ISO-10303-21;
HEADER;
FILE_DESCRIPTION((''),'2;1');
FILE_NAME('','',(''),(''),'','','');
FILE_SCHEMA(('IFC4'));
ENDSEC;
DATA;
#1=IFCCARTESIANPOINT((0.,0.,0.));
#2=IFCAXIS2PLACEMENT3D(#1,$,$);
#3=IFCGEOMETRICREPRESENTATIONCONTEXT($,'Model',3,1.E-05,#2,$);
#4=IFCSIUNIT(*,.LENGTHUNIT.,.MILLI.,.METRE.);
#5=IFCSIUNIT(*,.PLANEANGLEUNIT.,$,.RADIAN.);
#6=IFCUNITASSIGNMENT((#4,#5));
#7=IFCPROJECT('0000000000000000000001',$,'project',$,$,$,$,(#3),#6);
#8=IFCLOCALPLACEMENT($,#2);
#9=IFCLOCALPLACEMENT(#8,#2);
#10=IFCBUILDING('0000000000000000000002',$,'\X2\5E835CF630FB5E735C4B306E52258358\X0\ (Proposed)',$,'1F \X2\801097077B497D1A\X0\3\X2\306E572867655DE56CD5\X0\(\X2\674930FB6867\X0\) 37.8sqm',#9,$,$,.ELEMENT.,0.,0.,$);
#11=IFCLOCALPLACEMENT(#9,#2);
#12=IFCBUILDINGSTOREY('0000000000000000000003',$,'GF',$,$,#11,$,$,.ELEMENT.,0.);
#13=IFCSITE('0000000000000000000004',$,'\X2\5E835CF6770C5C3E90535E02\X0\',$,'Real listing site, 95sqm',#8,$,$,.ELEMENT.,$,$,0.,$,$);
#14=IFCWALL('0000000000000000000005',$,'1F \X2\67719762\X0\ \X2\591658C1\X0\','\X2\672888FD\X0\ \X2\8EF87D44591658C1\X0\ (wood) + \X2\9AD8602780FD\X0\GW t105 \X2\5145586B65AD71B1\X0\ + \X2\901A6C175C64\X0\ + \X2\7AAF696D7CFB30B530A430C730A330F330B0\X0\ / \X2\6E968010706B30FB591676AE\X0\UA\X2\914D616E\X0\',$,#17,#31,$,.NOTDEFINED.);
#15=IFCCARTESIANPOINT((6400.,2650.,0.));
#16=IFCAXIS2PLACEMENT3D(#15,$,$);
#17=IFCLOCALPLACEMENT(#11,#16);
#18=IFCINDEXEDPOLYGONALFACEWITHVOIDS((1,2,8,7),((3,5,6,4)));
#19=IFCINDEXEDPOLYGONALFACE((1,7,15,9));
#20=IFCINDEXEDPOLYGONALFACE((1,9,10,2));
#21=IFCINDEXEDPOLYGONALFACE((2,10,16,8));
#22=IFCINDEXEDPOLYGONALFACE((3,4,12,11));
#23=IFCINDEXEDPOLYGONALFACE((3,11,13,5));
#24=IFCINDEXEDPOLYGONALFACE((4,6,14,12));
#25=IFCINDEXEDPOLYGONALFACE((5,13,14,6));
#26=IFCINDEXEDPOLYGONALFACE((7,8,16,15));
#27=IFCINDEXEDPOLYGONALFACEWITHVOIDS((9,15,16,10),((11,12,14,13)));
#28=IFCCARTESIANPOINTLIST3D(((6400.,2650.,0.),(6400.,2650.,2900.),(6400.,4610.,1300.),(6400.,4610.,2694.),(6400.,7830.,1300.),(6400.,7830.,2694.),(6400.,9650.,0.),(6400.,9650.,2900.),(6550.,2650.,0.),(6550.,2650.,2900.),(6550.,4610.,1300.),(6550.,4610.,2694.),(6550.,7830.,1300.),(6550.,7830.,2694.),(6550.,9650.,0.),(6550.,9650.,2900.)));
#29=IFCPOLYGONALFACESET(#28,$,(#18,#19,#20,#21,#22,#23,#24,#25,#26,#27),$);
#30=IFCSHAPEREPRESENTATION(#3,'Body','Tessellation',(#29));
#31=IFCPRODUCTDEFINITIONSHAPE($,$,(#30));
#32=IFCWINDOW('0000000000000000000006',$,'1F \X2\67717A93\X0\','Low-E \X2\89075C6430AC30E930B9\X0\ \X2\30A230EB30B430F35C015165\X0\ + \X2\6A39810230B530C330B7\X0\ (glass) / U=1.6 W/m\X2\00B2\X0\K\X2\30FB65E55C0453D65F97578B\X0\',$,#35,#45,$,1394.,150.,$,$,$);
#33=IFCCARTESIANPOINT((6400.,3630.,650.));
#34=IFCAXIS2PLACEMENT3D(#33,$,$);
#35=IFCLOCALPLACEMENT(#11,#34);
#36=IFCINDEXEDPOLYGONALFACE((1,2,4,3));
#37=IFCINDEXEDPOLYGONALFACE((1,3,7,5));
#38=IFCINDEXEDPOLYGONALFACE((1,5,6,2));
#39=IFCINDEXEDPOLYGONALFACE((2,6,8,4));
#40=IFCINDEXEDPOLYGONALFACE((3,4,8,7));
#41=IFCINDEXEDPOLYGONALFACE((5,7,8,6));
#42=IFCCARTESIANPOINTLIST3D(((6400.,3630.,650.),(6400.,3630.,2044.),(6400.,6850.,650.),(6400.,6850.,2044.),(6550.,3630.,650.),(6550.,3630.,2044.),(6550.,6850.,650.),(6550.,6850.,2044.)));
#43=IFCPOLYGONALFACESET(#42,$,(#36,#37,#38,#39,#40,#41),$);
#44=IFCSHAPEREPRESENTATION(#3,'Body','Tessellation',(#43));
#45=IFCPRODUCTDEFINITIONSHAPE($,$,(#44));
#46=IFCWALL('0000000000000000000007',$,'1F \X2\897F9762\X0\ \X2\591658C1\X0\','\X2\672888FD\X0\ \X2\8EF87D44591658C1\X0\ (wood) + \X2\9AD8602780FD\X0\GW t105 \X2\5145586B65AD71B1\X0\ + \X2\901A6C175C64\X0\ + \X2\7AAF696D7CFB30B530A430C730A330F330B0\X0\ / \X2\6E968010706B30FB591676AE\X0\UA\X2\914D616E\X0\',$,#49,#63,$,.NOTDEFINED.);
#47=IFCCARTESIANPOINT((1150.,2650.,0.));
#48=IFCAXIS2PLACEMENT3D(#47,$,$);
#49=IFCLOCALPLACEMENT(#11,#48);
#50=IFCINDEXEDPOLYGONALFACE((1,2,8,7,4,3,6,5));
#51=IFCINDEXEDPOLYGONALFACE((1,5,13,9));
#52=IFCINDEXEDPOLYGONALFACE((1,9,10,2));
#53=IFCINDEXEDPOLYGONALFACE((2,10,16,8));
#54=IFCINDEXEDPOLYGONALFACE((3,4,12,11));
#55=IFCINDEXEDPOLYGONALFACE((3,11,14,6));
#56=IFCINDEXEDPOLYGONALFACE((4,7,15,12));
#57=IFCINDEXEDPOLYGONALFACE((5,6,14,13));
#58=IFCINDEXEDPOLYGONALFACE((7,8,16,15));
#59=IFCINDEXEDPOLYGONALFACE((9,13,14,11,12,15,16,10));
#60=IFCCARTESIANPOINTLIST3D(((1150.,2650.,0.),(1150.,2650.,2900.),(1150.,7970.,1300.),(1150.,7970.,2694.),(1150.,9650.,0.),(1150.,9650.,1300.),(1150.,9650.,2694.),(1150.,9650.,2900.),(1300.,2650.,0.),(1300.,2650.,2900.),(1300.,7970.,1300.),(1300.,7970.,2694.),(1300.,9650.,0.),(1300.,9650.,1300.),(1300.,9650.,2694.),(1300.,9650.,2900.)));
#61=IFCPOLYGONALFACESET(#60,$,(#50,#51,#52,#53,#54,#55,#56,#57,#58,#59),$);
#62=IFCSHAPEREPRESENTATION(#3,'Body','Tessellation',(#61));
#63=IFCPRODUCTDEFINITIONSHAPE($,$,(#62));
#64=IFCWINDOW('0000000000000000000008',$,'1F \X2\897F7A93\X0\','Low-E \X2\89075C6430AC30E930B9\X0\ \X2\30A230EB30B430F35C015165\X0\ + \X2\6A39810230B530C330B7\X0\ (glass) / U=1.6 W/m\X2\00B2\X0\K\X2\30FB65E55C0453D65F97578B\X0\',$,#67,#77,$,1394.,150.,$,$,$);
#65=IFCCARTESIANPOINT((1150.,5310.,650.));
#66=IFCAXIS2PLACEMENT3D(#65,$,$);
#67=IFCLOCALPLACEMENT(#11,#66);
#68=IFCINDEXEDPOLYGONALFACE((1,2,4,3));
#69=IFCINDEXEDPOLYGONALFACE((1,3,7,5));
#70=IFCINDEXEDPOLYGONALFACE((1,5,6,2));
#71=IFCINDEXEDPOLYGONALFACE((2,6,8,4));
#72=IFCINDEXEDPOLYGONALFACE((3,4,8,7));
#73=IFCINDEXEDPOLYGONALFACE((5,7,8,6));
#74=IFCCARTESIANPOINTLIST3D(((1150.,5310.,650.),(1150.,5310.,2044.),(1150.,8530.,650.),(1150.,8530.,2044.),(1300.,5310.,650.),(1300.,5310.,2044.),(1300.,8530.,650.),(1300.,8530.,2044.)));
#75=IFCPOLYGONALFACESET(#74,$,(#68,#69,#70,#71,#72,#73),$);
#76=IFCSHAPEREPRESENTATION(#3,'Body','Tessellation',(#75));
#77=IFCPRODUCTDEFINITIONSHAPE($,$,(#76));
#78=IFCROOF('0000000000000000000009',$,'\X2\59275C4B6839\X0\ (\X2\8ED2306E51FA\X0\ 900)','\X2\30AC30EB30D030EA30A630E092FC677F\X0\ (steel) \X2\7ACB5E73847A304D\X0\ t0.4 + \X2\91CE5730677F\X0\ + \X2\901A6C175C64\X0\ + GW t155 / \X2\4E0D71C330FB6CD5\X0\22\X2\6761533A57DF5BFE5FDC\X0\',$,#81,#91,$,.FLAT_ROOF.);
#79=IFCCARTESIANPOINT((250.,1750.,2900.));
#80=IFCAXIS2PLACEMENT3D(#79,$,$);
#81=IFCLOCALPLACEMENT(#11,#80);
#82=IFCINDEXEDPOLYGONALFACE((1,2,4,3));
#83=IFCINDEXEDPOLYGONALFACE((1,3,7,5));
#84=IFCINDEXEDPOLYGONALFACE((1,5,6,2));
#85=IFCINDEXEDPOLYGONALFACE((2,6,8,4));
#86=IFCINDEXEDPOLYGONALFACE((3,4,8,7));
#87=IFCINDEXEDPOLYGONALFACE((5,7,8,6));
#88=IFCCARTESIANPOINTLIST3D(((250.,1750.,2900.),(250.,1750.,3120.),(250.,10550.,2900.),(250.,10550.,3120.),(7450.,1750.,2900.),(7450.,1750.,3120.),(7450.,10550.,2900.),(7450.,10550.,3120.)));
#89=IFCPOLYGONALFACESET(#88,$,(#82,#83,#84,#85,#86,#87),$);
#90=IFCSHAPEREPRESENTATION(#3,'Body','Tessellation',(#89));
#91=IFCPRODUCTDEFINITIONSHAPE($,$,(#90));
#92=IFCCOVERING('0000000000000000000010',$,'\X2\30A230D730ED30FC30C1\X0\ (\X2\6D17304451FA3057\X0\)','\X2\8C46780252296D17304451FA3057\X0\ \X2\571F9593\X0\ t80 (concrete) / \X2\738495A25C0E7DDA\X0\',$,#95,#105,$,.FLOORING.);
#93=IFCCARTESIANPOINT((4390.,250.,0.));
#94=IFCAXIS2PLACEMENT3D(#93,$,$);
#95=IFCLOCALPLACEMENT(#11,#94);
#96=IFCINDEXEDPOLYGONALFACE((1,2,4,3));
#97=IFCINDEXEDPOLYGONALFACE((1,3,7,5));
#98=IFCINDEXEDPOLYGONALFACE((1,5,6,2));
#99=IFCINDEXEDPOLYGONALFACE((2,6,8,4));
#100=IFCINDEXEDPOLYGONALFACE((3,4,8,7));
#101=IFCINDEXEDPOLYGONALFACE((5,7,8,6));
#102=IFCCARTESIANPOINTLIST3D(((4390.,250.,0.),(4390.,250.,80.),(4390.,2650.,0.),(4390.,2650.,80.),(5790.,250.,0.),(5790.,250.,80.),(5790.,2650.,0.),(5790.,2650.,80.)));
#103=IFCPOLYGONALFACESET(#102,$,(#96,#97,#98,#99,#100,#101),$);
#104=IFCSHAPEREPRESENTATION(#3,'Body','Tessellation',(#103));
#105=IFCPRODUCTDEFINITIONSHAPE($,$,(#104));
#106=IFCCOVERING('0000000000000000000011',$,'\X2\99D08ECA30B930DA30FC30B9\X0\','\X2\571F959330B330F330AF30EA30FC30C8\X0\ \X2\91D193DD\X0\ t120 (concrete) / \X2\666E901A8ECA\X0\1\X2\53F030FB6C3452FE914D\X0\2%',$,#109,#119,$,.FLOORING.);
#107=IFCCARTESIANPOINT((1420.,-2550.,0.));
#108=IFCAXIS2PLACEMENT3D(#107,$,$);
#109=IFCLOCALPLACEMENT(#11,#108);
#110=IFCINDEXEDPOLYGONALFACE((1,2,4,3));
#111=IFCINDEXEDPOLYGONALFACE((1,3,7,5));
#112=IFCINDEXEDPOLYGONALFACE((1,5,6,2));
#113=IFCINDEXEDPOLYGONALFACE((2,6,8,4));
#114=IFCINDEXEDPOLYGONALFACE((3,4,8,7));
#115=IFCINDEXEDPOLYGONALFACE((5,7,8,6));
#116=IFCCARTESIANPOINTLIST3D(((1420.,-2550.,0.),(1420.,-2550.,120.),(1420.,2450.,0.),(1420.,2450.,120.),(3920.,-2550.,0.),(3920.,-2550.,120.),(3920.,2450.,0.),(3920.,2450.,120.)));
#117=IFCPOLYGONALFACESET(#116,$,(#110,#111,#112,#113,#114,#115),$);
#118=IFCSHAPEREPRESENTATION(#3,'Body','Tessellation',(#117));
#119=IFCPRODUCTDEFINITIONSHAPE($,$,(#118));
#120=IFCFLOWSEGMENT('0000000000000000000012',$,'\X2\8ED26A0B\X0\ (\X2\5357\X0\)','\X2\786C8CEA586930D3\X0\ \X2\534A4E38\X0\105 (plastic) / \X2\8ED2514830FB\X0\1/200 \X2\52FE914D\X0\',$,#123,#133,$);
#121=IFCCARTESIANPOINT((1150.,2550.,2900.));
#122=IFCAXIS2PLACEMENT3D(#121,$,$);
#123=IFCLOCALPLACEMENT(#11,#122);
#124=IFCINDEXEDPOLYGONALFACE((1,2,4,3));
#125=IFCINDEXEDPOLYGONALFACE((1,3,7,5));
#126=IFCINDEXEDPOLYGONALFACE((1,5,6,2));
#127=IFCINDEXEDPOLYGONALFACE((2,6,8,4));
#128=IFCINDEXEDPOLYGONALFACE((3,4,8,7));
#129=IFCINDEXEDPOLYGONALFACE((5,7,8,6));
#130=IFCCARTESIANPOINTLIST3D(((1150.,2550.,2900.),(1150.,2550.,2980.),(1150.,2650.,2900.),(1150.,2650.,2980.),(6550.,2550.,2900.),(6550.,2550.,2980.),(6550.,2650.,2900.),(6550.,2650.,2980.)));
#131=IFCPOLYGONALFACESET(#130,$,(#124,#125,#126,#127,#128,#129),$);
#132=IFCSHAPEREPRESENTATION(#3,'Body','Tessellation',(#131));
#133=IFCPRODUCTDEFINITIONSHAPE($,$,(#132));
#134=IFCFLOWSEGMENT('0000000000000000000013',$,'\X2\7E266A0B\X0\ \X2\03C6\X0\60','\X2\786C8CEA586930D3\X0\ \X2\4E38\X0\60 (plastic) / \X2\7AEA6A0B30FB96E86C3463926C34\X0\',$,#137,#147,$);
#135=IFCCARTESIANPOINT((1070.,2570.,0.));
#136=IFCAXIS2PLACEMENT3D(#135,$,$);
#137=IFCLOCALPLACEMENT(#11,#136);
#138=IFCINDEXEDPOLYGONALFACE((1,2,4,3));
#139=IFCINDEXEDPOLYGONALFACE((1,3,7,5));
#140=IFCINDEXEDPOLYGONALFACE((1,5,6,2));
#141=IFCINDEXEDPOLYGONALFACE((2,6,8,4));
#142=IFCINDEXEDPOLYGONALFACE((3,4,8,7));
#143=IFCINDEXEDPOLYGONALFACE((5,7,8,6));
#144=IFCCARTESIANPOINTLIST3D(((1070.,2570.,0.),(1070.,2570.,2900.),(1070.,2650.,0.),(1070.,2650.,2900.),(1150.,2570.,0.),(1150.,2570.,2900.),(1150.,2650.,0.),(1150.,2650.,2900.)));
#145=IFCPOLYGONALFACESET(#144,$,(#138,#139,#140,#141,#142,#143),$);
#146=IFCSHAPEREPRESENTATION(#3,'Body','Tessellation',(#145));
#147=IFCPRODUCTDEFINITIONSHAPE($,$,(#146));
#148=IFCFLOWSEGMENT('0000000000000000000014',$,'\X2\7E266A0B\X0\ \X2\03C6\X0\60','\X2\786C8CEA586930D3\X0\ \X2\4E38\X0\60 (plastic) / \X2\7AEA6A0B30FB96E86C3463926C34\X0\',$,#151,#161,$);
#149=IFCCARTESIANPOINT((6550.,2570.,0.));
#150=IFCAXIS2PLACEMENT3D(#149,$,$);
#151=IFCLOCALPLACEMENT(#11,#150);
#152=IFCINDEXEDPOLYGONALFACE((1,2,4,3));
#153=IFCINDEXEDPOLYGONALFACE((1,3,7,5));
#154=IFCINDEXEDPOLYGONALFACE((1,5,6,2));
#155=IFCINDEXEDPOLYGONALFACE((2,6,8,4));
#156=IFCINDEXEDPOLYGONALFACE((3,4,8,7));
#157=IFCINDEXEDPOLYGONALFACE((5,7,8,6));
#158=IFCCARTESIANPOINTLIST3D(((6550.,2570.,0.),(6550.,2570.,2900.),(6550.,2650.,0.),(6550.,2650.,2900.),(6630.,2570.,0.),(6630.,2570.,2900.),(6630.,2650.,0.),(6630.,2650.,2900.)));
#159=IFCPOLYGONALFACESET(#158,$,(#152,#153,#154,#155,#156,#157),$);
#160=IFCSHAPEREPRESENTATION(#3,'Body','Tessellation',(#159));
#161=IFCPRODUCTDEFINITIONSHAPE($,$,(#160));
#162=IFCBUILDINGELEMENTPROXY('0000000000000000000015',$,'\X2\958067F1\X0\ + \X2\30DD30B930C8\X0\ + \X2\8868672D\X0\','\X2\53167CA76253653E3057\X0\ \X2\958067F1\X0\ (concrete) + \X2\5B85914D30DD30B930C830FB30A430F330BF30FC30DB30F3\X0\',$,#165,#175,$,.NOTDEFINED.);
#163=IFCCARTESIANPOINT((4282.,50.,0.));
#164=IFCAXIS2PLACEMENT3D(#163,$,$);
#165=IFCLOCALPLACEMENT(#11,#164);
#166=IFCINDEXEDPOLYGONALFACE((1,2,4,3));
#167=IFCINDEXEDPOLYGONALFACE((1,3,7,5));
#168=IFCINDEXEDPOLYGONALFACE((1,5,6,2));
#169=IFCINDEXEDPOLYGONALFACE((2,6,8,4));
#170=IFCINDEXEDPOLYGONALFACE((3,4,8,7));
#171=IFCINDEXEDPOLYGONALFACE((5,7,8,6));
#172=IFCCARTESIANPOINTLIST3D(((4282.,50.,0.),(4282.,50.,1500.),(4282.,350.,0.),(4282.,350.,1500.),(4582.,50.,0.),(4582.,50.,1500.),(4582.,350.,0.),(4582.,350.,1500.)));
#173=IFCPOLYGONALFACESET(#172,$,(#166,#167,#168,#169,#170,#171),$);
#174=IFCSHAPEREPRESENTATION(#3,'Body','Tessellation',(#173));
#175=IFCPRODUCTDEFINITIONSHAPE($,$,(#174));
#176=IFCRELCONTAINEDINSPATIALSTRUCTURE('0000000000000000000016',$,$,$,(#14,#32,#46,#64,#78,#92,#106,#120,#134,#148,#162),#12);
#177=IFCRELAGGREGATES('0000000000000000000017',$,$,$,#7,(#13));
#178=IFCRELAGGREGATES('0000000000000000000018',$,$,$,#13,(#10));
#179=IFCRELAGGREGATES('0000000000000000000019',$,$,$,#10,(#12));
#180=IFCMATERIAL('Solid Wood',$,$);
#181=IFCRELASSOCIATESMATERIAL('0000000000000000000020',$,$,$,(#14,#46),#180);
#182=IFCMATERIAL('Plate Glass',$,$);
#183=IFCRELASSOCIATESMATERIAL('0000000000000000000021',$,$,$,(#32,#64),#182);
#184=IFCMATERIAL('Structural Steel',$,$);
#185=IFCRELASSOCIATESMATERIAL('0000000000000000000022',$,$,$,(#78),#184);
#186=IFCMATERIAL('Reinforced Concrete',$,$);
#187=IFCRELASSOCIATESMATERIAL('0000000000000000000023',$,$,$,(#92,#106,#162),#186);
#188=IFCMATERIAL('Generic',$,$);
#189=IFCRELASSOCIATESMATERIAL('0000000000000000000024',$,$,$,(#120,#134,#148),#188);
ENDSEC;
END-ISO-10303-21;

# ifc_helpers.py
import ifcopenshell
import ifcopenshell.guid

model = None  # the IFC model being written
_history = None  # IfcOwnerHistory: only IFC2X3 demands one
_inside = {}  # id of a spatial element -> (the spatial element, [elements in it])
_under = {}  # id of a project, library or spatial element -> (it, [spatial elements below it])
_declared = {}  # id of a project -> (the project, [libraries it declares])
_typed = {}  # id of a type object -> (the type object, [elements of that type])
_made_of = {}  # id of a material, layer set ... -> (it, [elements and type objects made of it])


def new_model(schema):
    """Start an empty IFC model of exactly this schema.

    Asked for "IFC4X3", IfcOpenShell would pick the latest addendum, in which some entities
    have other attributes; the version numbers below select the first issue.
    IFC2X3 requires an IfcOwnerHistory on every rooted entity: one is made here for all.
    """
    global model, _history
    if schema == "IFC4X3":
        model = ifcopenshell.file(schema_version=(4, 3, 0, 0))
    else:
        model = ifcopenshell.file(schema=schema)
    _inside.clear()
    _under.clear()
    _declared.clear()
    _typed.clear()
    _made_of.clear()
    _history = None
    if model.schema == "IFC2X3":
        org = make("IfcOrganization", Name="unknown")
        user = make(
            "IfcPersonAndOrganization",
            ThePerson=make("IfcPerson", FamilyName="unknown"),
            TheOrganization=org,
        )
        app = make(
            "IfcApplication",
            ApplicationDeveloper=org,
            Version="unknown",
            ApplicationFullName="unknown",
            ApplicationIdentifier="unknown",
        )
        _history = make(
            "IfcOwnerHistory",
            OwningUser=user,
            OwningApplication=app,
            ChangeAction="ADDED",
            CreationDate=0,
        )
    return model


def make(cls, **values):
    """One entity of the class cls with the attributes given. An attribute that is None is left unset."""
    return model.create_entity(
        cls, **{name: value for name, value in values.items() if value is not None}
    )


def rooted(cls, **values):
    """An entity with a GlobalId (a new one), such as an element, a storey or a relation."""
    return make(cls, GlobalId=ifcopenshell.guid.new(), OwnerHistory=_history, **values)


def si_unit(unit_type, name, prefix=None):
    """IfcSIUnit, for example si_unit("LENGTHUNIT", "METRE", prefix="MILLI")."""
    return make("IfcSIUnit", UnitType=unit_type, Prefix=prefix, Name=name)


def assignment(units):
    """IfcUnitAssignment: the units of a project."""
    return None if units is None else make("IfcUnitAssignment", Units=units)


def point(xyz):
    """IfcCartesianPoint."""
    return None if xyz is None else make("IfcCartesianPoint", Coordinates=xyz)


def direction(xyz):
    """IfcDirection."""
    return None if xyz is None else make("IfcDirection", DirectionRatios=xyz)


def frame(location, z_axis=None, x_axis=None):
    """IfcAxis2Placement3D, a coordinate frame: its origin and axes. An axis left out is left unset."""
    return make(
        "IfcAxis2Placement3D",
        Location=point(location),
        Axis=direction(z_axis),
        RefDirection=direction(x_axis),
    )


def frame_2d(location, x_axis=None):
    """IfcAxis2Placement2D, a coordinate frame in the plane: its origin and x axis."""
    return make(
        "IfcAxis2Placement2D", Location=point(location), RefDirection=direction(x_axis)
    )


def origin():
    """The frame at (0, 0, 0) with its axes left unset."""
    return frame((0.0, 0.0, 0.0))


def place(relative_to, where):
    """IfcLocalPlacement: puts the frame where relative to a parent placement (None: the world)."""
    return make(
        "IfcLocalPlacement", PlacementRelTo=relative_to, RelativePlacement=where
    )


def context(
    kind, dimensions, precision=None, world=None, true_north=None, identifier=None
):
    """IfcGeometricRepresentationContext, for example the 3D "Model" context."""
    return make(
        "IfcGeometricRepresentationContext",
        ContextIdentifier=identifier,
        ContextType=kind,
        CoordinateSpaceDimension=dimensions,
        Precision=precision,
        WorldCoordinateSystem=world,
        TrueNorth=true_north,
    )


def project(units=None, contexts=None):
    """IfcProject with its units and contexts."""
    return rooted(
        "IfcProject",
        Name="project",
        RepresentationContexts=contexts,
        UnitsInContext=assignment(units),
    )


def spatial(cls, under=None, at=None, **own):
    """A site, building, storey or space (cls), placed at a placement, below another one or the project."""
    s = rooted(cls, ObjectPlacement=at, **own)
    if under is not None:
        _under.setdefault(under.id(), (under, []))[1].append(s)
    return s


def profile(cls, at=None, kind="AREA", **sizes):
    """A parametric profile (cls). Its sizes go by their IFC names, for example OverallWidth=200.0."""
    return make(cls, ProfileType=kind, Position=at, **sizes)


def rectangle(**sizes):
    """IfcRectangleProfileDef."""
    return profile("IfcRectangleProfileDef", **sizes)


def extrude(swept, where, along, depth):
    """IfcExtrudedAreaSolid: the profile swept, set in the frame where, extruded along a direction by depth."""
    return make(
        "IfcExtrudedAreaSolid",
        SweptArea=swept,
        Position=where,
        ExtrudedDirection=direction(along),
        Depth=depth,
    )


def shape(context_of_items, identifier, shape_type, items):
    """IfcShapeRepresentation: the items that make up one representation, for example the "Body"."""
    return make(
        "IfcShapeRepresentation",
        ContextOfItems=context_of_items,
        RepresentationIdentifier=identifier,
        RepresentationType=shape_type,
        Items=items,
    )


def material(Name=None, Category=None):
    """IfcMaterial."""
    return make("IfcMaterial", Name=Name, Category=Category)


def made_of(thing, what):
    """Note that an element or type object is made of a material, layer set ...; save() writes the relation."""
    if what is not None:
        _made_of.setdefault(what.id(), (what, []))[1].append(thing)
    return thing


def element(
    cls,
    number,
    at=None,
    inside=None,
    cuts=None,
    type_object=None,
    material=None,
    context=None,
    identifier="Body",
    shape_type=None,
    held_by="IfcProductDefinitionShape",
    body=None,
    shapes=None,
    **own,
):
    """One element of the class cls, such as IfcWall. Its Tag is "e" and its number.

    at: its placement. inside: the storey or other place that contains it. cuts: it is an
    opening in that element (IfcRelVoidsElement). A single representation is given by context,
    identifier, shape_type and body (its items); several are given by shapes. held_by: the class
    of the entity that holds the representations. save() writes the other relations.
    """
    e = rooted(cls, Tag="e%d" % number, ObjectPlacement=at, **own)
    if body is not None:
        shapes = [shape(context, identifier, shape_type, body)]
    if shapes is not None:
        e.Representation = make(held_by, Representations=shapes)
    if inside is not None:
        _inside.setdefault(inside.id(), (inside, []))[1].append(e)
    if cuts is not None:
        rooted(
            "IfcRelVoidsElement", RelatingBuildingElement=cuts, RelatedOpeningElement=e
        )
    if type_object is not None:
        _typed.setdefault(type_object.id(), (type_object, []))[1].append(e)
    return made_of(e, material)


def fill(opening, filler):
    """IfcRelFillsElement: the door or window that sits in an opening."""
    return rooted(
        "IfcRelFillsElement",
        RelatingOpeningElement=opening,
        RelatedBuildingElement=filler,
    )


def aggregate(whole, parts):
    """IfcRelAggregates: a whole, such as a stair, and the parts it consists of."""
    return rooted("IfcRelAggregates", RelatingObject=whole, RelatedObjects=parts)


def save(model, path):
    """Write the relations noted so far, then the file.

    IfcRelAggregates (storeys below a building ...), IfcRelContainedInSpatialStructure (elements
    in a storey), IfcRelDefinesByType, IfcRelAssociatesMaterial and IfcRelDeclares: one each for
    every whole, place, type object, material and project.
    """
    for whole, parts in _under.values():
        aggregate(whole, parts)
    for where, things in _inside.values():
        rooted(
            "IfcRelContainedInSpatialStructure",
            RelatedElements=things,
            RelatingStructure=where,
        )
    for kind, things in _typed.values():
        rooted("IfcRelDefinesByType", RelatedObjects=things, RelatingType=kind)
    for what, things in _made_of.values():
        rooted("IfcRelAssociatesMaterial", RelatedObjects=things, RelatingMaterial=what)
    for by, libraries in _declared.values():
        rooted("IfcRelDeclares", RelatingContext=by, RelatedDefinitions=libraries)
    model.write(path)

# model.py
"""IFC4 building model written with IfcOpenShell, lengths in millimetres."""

from ifc_helpers import new_model, si_unit, frame, frame_2d, origin, place, context, project, spatial, rectangle, extrude, material, element, fill, save


model = new_model("IFC4")

# Units and contexts
model_context = context("Model", 3, precision=1e-05, world=origin())
ifc_project = project(units=[si_unit("LENGTHUNIT", "METRE", prefix="MILLI"), si_unit("PLANEANGLEUNIT", "RADIAN")], contexts=[model_context])

# Site, building, storey
site_placement = place(None, origin())
site = spatial("IfcSite", under=ifc_project, at=site_placement, Name="広島県尾道市", ObjectType="Real listing site, 95sqm", CompositionType="ELEMENT", RefElevation=0.0)
building_placement = place(site_placement, origin())
building = spatial("IfcBuilding", under=site, at=building_placement, Name="広島・平屋の別荘 (Proposed)", ObjectType="1F 耐震等級3の在来工法(杉・桧) 37.8sqm", CompositionType="ELEMENT", ElevationOfRefHeight=0.0, ElevationOfTerrain=0.0)
storey_placement = place(building_placement, origin())
storey = spatial("IfcBuildingStorey", under=building, at=storey_placement, Name="GF", CompositionType="ELEMENT", Elevation=0.0)

# Shared definitions
ifc_material_1 = material(Name="Solid Wood")

# Shared definitions
ifc_material_2 = material(Name="Reinforced Concrete")

# Shared definitions
ifc_material_3 = material(Name="Plate Glass")

# Walls, openings, windows
wall_1_placement = place(storey_placement, frame((6400.0, 2650.0, 0.0)))
wall_1 = element("IfcWall", 1, at=wall_1_placement, inside=storey, material=ifc_material_1, Name="1F 東面 外壁", Description="木製 軸組外壁 (wood) + 高性能GW t105 充填断熱 + 通気層 + 窯業系サイディング / 準耐火・外皮UA配慮", PredefinedType="NOTDEFINED", context=model_context, shape_type="SweptSolid", body=[
    extrude(rectangle(XDim=150.0, YDim=7000.0, at=frame_2d((75.0, 3500.0))), frame((6400.0, 2650.0, 0.0)), (0.0, 0.0, 1.0), 2900.0),
])
opening_1_placement = place(storey_placement, frame((6400.0, 3630.0, 650.0)))
opening_1 = element("IfcOpeningElement", 2, at=opening_1_placement, cuts=wall_1, PredefinedType="NOTDEFINED", context=model_context, shape_type="SweptSolid", body=[
    extrude(rectangle(XDim=150.0, YDim=3220.0, at=frame_2d((75.0, 1610.0))), frame((6400.0, 3630.0, 650.0)), (0.0, 0.0, 1.0), 1394.0),
])
window_1_placement = place(storey_placement, frame((6400.0, 3630.0, 650.0)))
window_1 = element("IfcWindow", 3, at=window_1_placement, inside=storey, material=ifc_material_3, Name="1F 東窓", Description="Low-E 複層ガラス アルゴン封入 + 樹脂サッシ (glass) / U=1.6 W/m²K・日射取得型", OverallHeight=1394.0, OverallWidth=150.0, context=model_context, shape_type="SweptSolid", body=[
    extrude(rectangle(XDim=150.0, YDim=3220.0, at=frame_2d((75.0, 1610.0))), frame((6400.0, 3630.0, 650.0)), (0.0, 0.0, 1.0), 1394.0),
])
fill(opening_1, window_1)
wall_2_placement = place(storey_placement, frame((1150.0, 2650.0, 0.0)))
wall_2 = element("IfcWall", 4, at=wall_2_placement, inside=storey, material=ifc_material_1, Name="1F 西面 外壁", Description="木製 軸組外壁 (wood) + 高性能GW t105 充填断熱 + 通気層 + 窯業系サイディング / 準耐火・外皮UA配慮", PredefinedType="NOTDEFINED", context=model_context, shape_type="SweptSolid", body=[
    extrude(rectangle(XDim=150.0, YDim=7000.0, at=frame_2d((75.0, 3500.0))), frame((1150.0, 2650.0, 0.0)), (0.0, 0.0, 1.0), 2900.0),
])
opening_2_placement = place(storey_placement, frame((1150.0, 5310.0, 650.0)))
opening_2 = element("IfcOpeningElement", 5, at=opening_2_placement, cuts=wall_2, PredefinedType="NOTDEFINED", context=model_context, shape_type="SweptSolid", body=[
    extrude(rectangle(XDim=150.0, YDim=3220.0, at=frame_2d((75.0, 1610.0))), frame((1150.0, 5310.0, 650.0)), (0.0, 0.0, 1.0), 1394.0),
])
window_2_placement = place(storey_placement, frame((1150.0, 5310.0, 650.0)))
window_2 = element("IfcWindow", 6, at=window_2_placement, inside=storey, material=ifc_material_3, Name="1F 西窓", Description="Low-E 複層ガラス アルゴン封入 + 樹脂サッシ (glass) / U=1.6 W/m²K・日射取得型", OverallHeight=1394.0, OverallWidth=150.0, context=model_context, shape_type="SweptSolid", body=[
    extrude(rectangle(XDim=150.0, YDim=3220.0, at=frame_2d((75.0, 1610.0))), frame((1150.0, 5310.0, 650.0)), (0.0, 0.0, 1.0), 1394.0),
])
fill(opening_2, window_2)

# Roof
ifc_material_4 = material(Name="Structural Steel")
roof_placement = place(storey_placement, frame((250.0, 1750.0, 2900.0)))
element("IfcRoof", 7, at=roof_placement, inside=storey, material=ifc_material_4, Name="大屋根 (軒の出 900)", Description="ガルバリウム鋼板 (steel) 立平葺き t0.4 + 野地板 + 通気層 + GW t155 / 不燃・法22条区域対応", PredefinedType="FLAT_ROOF", context=model_context, shape_type="SweptSolid", body=[
    extrude(rectangle(XDim=7200.0, YDim=8800.0, at=frame_2d((3600.0, 4400.0))), frame((250.0, 1750.0, 2900.0)), (0.0, 0.0, 1.0), 220.0),
])

# Coverings
covering_1_placement = place(storey_placement, frame((4390.0, 250.0, 0.0)))
element("IfcCovering", 8, at=covering_1_placement, inside=storey, material=ifc_material_2, Name="アプローチ (洗い出し)", Description="豆砂利洗い出し 土間 t80 (concrete) / 玄関導線", PredefinedType="FLOORING", context=model_context, shape_type="SweptSolid", body=[
    extrude(rectangle(XDim=1400.0, YDim=2400.0, at=frame_2d((700.0, 1200.0))), frame((4390.0, 250.0, 0.0)), (0.0, 0.0, 1.0), 80.0),
])
covering_2_placement = place(storey_placement, frame((1420.0, -2550.0, 0.0)))
element("IfcCovering", 9, at=covering_2_placement, inside=storey, material=ifc_material_2, Name="駐車スペース", Description="土間コンクリート 金鏝 t120 (concrete) / 普通車1台・水勾配2%", PredefinedType="FLOORING", context=model_context, shape_type="SweptSolid", body=[
    extrude(rectangle(XDim=2500.0, YDim=5000.0, at=frame_2d((1250.0, 2500.0))), frame((1420.0, -2550.0, 0.0)), (0.0, 0.0, 1.0), 120.0),
])

# Flow segments
ifc_material_5 = material(Name="Generic")
flow_segment_1_placement = place(storey_placement, frame((1150.0, 2550.0, 2900.0)))
element("IfcFlowSegment", 10, at=flow_segment_1_placement, inside=storey, material=ifc_material_5, Name="軒樋 (南)", Description="硬質塩ビ 半丸105 (plastic) / 軒先・1/200 勾配", context=model_context, shape_type="SweptSolid", body=[
    extrude(rectangle(XDim=5400.0, YDim=100.0, at=frame_2d((2700.0, 50.0))), frame((1150.0, 2550.0, 2900.0)), (0.0, 0.0, 1.0), 80.0),
])
flow_segment_2_placement = place(storey_placement, frame((1070.0, 2570.0, 0.0)))
element("IfcFlowSegment", 11, at=flow_segment_2_placement, inside=storey, material=ifc_material_5, Name="縦樋 φ60", Description="硬質塩ビ 丸60 (plastic) / 竪樋・雨水排水", context=model_context, shape_type="SweptSolid", body=[
    extrude(rectangle(XDim=80.0, YDim=80.0, at=frame_2d((40.0, 40.0))), frame((1070.0, 2570.0, 0.0)), (0.0, 0.0, 1.0), 2900.0),
])
flow_segment_3_placement = place(storey_placement, frame((6550.0, 2570.0, 0.0)))
element("IfcFlowSegment", 12, at=flow_segment_3_placement, inside=storey, material=ifc_material_5, Name="縦樋 φ60", Description="硬質塩ビ 丸60 (plastic) / 竪樋・雨水排水", context=model_context, shape_type="SweptSolid", body=[
    extrude(rectangle(XDim=80.0, YDim=80.0, at=frame_2d((40.0, 40.0))), frame((6550.0, 2570.0, 0.0)), (0.0, 0.0, 1.0), 2900.0),
])

# Building element proxy
proxy_placement = place(storey_placement, frame((4282.0, 50.0, 0.0)))
element("IfcBuildingElementProxy", 13, at=proxy_placement, inside=storey, material=ifc_material_2, Name="門柱 + ポスト + 表札", Description="化粧打放し 門柱 (concrete) + 宅配ポスト・インターホン", PredefinedType="NOTDEFINED", context=model_context, shape_type="SweptSolid", body=[
    extrude(rectangle(XDim=300.0, YDim=300.0, at=frame_2d((150.0, 150.0))), frame((4282.0, 50.0, 0.0)), (0.0, 0.0, 1.0), 1500.0),
])

save(model, "model.ifc")
